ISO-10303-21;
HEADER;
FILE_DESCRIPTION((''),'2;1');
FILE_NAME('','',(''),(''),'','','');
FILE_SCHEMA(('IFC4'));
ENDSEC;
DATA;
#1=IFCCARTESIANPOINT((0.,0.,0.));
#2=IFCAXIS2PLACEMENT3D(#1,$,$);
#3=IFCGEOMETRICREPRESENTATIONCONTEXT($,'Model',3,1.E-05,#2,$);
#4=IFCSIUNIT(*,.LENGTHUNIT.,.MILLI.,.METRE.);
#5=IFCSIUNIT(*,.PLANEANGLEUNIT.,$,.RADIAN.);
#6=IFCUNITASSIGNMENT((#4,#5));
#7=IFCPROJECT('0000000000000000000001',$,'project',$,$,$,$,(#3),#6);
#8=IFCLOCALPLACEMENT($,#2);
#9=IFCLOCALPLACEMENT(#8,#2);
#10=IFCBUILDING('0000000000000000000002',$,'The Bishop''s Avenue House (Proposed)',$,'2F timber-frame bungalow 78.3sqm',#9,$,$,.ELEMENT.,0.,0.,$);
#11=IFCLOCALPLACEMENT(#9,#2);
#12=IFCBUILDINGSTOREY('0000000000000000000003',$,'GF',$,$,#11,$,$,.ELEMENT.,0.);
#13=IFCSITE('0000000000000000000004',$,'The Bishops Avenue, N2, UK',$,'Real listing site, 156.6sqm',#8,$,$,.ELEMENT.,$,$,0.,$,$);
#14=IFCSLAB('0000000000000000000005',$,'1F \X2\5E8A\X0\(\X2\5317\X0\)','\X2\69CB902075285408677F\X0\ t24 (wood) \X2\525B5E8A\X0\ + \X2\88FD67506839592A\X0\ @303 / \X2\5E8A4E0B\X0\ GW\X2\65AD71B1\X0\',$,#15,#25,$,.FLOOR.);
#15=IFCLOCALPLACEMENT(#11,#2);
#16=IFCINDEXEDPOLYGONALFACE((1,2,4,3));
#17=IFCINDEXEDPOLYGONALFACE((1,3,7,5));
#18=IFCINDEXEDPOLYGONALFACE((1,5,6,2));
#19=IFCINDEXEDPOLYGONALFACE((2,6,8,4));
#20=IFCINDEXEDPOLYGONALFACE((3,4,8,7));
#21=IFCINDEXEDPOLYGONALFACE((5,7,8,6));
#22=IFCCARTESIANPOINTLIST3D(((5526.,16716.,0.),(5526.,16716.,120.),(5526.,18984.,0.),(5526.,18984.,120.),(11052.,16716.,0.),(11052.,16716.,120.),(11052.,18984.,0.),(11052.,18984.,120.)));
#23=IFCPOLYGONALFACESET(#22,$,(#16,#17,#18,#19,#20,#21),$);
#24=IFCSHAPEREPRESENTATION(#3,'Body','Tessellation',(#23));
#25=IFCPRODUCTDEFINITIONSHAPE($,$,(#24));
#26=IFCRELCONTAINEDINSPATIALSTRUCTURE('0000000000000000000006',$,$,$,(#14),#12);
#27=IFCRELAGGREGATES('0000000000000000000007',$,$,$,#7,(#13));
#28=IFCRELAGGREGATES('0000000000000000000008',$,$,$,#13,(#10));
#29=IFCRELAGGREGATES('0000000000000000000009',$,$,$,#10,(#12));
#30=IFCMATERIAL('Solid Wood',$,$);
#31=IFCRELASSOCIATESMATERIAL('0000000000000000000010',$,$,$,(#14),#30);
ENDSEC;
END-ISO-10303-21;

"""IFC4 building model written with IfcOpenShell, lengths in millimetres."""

from ifc_helpers import new_model, si_unit, frame, frame_2d, origin, place, context, project, spatial, rectangle, extrude, material, element, save


model = new_model("IFC4")

# Units and contexts
model_context = context("Model", 3, precision=1e-05, world=origin())
ifc_project = project(units=[si_unit("LENGTHUNIT", "METRE", prefix="MILLI"), si_unit("PLANEANGLEUNIT", "RADIAN")], contexts=[model_context])

# Site, building, storey
site_placement = place(None, origin())
site = spatial("IfcSite", under=ifc_project, at=site_placement, Name="The Bishops Avenue, N2, UK", ObjectType="Real listing site, 156.6sqm", CompositionType="ELEMENT", RefElevation=0.0)
building_placement = place(site_placement, origin())
building = spatial("IfcBuilding", under=site, at=building_placement, Name="The Bishop's Avenue House (Proposed)", ObjectType="2F timber-frame bungalow 78.3sqm", CompositionType="ELEMENT", ElevationOfRefHeight=0.0, ElevationOfTerrain=0.0)
storey_placement = place(building_placement, origin())
storey = spatial("IfcBuildingStorey", under=building, at=storey_placement, Name="GF", CompositionType="ELEMENT", Elevation=0.0)

# Slab
ifc_material_1 = material(Name="Solid Wood")
slab_1_placement = place(storey_placement, frame((2763.0, 8358.0, 0.0)))
element("IfcSlab", 1, at=slab_1_placement, inside=storey, material=ifc_material_1, Name="1F 床(北)", Description="構造用合板 t24 (wood) 剛床 + 製材根太 @303 / 床下 GW断熱", PredefinedType="FLOOR", context=model_context, shape_type="SweptSolid", body=[
    extrude(rectangle(XDim=5526.0, YDim=2268.0, at=frame_2d((2763.0, 1134.0))), frame((2763.0, 8358.0, 0.0)), (0.0, 0.0, 1.0), 120.0),
])

save(model, "model.ifc")
